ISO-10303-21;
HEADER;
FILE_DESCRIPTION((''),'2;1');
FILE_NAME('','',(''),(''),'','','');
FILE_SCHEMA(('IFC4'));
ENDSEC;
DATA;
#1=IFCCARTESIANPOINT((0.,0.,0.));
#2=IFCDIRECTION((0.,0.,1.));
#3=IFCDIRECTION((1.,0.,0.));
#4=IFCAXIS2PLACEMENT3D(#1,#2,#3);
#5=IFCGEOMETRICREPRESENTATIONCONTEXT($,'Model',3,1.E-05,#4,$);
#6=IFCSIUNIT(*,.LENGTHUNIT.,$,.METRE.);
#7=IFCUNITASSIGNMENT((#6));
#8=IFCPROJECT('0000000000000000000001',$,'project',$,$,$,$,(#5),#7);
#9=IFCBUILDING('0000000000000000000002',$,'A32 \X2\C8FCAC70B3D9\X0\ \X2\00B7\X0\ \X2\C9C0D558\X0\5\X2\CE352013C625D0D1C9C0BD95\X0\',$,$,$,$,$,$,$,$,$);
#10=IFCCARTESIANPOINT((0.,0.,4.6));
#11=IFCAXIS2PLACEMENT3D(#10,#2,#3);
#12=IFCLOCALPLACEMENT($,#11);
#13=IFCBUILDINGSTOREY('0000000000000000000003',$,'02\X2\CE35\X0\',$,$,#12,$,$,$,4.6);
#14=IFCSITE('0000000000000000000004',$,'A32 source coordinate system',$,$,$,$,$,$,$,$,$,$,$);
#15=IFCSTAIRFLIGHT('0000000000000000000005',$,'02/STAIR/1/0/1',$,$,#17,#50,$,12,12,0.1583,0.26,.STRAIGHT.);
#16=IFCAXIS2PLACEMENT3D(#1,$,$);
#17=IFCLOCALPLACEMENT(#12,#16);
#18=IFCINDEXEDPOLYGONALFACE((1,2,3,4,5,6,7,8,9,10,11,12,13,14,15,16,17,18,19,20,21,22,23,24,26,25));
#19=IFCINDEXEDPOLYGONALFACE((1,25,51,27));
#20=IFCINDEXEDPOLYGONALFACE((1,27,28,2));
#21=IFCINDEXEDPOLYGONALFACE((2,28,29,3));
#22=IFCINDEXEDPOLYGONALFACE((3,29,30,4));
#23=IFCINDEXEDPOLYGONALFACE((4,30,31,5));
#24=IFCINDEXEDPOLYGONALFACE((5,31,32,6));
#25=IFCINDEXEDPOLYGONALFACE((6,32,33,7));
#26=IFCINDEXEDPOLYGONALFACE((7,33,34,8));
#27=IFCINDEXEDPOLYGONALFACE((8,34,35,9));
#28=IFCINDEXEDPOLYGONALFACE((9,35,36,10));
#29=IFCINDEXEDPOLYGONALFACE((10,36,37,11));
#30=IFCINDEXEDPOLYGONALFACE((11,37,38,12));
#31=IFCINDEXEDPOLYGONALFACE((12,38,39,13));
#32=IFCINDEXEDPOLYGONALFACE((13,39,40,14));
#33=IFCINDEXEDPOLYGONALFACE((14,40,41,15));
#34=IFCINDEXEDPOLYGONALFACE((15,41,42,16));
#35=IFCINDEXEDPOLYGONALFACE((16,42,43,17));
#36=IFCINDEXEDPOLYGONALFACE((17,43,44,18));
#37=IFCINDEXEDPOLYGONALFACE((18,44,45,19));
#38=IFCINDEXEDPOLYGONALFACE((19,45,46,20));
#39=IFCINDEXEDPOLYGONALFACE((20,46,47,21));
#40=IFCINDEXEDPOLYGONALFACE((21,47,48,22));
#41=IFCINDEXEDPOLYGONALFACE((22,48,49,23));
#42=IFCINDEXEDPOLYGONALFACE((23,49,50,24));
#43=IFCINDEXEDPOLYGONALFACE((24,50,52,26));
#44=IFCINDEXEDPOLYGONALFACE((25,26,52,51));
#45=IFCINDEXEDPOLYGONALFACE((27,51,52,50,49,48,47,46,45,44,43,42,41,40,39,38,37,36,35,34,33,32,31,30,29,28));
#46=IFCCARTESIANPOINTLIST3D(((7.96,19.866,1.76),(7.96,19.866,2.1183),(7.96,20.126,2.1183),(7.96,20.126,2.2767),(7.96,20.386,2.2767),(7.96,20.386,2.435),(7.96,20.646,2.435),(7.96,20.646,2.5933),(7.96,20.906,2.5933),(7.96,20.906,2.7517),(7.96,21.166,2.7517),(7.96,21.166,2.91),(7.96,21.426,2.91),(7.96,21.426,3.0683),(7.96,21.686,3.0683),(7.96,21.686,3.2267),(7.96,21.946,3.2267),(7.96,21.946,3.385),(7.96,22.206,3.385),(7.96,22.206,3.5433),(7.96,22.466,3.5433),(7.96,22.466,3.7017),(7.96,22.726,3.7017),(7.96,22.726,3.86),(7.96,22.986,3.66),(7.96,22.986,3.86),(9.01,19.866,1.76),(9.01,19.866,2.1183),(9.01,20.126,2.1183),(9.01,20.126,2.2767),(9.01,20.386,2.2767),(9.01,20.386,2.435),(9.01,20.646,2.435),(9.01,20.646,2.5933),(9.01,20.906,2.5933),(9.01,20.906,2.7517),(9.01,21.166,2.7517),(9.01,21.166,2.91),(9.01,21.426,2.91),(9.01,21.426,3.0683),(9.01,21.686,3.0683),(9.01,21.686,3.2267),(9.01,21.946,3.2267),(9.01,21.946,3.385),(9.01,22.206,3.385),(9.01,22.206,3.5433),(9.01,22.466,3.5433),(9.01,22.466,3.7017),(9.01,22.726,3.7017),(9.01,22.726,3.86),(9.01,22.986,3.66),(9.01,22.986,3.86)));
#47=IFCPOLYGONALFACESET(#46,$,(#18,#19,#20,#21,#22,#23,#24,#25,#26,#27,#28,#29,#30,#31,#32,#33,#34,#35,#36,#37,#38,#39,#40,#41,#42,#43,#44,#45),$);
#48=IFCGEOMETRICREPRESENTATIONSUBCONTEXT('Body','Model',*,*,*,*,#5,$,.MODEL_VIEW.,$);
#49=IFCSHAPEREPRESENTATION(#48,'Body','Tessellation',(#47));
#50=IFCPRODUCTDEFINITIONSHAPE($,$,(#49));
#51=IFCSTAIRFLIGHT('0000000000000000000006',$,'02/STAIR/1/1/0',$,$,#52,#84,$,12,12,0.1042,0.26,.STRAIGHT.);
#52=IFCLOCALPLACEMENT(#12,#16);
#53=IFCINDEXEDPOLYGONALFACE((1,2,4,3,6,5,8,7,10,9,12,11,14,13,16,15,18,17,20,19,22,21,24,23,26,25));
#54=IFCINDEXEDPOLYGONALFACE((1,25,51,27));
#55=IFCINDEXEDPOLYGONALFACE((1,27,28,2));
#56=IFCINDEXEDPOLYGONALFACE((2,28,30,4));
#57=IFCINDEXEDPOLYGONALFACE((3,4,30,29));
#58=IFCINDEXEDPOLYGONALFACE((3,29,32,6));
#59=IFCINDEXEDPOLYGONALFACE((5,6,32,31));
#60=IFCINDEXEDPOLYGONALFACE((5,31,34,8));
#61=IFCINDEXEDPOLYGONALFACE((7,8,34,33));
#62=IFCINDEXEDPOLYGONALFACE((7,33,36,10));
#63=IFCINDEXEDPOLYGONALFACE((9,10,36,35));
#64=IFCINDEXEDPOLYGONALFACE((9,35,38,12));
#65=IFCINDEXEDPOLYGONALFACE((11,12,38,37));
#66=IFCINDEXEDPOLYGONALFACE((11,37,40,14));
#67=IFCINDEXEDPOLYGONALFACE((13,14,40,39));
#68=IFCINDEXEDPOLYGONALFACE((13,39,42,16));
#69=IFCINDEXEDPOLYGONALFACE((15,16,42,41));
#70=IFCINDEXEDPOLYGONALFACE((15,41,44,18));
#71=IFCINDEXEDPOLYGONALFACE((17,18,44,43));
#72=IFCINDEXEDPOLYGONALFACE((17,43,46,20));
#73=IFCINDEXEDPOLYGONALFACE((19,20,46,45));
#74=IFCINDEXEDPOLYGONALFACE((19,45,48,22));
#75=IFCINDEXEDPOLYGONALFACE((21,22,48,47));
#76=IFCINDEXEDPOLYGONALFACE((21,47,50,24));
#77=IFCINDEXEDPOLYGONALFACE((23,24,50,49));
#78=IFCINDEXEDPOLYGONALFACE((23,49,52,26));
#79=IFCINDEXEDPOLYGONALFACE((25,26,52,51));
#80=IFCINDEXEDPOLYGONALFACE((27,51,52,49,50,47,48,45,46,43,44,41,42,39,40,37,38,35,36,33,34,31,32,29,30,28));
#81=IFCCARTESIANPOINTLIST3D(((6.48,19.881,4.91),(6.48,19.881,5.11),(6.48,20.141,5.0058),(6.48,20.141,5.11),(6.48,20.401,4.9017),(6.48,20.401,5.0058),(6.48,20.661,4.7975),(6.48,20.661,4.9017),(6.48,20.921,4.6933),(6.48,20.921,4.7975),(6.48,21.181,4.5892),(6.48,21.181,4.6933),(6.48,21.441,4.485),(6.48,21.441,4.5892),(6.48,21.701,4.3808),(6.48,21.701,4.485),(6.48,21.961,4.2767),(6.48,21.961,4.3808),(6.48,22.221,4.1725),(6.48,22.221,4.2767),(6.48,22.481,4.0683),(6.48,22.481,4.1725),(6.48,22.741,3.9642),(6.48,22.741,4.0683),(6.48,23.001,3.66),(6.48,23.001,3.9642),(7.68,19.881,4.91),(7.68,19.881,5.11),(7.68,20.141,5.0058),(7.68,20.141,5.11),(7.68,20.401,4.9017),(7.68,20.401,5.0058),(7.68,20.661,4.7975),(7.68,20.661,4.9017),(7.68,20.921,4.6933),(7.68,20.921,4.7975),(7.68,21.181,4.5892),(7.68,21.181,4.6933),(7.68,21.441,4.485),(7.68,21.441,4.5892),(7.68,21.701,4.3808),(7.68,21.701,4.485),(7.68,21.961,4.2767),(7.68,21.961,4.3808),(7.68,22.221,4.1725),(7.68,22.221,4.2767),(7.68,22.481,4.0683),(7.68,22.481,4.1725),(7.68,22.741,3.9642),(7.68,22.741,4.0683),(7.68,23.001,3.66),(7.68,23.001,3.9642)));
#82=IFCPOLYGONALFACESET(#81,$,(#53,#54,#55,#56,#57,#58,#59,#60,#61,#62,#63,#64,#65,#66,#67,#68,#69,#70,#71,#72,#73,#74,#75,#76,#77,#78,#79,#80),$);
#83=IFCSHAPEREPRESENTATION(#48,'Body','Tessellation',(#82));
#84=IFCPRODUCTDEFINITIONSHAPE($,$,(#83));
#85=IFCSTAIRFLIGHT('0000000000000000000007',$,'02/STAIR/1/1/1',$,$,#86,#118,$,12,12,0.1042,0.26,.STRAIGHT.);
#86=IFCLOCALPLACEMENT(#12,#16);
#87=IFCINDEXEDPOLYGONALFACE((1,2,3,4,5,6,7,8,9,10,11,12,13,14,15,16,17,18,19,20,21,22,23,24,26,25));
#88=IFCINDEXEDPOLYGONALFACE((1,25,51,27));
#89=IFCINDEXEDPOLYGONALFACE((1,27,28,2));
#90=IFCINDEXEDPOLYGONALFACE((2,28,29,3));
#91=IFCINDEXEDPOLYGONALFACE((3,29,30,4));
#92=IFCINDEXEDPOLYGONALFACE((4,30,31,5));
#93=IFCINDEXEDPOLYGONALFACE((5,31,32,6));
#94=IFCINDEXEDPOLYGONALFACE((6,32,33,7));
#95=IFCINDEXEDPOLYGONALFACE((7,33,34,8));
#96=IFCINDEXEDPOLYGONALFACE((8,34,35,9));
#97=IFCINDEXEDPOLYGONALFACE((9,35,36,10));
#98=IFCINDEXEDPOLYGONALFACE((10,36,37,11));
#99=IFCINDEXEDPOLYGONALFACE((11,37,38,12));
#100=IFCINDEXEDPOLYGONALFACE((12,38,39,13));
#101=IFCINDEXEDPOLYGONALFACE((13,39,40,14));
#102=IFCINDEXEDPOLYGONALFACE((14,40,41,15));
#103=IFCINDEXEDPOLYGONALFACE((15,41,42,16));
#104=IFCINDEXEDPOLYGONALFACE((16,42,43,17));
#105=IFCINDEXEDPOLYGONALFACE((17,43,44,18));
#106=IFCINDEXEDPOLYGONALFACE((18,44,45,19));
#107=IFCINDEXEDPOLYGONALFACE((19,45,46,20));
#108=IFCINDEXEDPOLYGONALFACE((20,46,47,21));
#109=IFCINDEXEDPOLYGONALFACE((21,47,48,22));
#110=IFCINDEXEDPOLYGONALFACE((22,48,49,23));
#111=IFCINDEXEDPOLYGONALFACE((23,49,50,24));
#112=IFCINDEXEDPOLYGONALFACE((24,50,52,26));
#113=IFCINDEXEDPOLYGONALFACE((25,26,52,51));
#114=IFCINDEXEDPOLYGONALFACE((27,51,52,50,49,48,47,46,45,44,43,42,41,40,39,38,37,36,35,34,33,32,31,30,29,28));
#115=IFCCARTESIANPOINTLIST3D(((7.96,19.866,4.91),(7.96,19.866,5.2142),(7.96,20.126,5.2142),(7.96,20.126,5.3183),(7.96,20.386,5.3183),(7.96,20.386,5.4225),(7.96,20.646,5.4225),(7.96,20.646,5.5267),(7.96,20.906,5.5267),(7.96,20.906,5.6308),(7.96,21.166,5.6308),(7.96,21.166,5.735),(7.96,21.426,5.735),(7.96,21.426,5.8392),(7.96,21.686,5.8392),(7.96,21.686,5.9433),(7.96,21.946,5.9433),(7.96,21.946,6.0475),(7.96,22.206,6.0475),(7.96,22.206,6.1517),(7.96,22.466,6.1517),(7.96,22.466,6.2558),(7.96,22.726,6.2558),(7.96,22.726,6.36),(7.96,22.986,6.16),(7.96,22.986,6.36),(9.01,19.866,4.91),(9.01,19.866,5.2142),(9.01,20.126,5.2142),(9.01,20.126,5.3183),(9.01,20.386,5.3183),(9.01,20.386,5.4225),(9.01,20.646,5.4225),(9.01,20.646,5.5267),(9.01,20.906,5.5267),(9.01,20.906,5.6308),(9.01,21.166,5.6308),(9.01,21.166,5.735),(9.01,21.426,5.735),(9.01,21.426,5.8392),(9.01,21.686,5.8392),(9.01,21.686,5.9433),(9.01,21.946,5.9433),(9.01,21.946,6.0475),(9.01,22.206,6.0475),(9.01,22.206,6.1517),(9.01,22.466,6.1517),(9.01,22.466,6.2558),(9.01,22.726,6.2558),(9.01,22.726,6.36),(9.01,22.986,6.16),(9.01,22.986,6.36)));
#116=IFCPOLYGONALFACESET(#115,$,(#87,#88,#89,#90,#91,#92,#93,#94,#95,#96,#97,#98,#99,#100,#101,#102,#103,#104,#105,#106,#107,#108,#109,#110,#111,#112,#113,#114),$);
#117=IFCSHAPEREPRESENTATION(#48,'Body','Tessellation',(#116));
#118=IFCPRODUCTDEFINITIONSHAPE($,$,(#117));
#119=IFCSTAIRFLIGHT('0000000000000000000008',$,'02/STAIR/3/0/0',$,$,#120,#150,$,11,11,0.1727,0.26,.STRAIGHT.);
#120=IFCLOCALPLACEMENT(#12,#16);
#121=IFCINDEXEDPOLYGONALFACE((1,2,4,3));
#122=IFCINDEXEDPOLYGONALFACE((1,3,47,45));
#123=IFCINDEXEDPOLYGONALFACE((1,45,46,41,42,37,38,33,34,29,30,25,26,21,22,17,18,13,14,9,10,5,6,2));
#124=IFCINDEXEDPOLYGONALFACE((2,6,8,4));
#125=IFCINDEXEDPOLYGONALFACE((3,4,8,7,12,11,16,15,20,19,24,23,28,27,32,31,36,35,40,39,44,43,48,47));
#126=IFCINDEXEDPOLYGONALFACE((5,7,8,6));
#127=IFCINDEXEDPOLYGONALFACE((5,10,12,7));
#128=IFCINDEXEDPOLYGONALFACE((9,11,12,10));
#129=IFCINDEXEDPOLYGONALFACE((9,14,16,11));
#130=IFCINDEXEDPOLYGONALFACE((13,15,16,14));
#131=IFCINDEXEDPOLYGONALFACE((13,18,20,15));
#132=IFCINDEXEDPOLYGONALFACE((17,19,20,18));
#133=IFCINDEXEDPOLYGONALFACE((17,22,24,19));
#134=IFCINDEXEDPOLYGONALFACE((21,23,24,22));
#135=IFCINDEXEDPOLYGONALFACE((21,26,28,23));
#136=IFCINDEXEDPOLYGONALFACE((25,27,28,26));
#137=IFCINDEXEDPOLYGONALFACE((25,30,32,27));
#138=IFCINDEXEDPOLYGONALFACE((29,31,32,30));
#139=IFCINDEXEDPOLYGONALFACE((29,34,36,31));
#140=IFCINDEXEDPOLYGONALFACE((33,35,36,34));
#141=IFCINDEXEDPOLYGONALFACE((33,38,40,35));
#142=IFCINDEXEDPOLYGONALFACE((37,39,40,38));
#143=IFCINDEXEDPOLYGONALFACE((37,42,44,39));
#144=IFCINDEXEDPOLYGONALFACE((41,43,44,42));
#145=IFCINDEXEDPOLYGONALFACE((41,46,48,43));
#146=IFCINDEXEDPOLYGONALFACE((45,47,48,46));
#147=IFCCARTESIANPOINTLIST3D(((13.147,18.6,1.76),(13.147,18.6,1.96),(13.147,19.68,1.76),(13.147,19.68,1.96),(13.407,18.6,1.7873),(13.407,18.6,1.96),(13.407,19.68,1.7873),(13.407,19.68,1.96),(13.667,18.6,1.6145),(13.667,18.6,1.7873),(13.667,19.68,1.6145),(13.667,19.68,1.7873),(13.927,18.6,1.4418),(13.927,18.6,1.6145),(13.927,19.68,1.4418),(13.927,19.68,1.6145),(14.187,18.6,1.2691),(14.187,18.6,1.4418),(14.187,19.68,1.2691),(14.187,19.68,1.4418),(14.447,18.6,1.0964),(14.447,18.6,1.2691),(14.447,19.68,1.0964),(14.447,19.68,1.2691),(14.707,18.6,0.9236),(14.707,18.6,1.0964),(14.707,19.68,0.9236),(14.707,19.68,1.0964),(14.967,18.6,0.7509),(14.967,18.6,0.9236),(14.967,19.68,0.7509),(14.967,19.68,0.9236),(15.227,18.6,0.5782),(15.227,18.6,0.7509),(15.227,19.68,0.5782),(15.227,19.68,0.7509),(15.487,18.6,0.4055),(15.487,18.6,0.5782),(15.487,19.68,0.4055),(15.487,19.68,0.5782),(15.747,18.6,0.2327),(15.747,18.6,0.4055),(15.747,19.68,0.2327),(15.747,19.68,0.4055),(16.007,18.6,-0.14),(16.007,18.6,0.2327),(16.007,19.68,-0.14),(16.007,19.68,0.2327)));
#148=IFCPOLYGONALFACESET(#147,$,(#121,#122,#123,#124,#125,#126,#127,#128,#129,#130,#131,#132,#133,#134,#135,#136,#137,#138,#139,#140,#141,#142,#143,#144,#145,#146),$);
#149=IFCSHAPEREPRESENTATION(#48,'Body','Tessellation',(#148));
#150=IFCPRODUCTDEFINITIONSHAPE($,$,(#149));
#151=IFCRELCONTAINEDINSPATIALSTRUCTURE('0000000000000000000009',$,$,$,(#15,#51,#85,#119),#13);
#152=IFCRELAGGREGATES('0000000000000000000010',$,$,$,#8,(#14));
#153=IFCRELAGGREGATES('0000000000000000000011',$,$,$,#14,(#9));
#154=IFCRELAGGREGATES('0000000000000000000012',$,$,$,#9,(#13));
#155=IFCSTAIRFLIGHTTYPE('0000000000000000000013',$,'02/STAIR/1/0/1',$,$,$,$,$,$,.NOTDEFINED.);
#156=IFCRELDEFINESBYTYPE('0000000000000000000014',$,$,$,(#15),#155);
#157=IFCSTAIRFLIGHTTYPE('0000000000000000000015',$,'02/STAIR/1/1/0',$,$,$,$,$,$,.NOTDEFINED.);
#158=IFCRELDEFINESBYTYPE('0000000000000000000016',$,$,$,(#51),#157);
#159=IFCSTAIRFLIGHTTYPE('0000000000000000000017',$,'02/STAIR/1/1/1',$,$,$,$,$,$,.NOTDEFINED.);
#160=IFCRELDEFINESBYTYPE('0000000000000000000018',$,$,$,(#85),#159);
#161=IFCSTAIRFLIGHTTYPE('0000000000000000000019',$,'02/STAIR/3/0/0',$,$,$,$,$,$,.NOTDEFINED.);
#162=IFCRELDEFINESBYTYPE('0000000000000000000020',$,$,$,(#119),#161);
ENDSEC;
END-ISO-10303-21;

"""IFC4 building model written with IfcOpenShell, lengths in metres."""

from ifc_helpers import new_model, si_unit, frame, origin, origin_with_axes, place, context, subcontext, project, spatial, polyline, outline, extrude, source, transform, mapped, type_object, type_shapes, element, save


model = new_model("IFC4")

# Units and contexts
model_context = context("Model", 3, precision=1e-05, world=origin_with_axes())
body_context = subcontext(model_context, "Body", "Model", "MODEL_VIEW")
ifc_project = project(units=[si_unit("LENGTHUNIT", "METRE")], contexts=[model_context])

# Site, building, storey
storey_placement = place(None, frame((0.0, 0.0, 4.6), z_axis=(0.0, 0.0, 1.0), x_axis=(1.0, 0.0, 0.0)))
site = spatial("IfcSite", under=ifc_project, Name="A32 source coordinate system")
building = spatial("IfcBuilding", under=site, Name="A32 주거동 · 지하5층–옥탑지붕")
storey = spatial("IfcBuildingStorey", under=building, at=storey_placement, Name="02층", Elevation=4.6)

# Stair flights
stair_flight_type_1 = type_object("IfcStairFlightType", Name="02/STAIR/1/0/1", PredefinedType="NOTDEFINED")
shared_shape_1 = source(origin(), body_context, "Body", "SweptSolid", [
    extrude(outline(polyline([(0.0, 1.76), (3.12, 3.66), (3.12, 3.86), (2.86, 3.86), (2.86, 3.7017), (2.6, 3.7017), (2.6, 3.5433), (2.34, 3.5433), (2.34, 3.385), (2.08, 3.385), (2.08, 3.2267), (1.82, 3.2267), (1.82, 3.0683), (1.56, 3.0683), (1.56, 2.91), (1.3, 2.91), (1.3, 2.7517), (1.04, 2.7517), (1.04, 2.5933), (0.78, 2.5933), (0.78, 2.435), (0.52, 2.435), (0.52, 2.2767), (0.26, 2.2767), (0.26, 2.1183), (0.0, 2.1183), (0.0, 1.76)])), frame((7.96, 19.866, 0.0), z_axis=(1.0, 0.0, 0.0), x_axis=(0.0, 1.0, 0.0)), (0.0, 0.0, 1.0), 1.05),
])
type_shapes(stair_flight_type_1, [shared_shape_1])
stair_flight_1_placement = place(storey_placement, origin_with_axes())
element("IfcStairFlight", 1, at=stair_flight_1_placement, inside=storey, type_object=stair_flight_type_1, Name="02/STAIR/1/0/1", NumberOfRisers=12, NumberOfTreads=12, PredefinedType="STRAIGHT", RiserHeight=0.1583, TreadLength=0.26, context=body_context, shape_type="MappedRepresentation", body=[
    mapped(shared_shape_1, transform((0.0, 0.0, 0.0), scale=1.0)),
])
stair_flight_type_2 = type_object("IfcStairFlightType", Name="02/STAIR/1/1/0", PredefinedType="NOTDEFINED")
shared_shape_2 = source(origin(), body_context, "Body", "SweptSolid", [
    extrude(outline(polyline([(0.0, 3.66), (3.12, 4.91), (3.12, 5.11), (2.86, 5.11), (2.86, 5.0058), (2.6, 5.0058), (2.6, 4.9017), (2.34, 4.9017), (2.34, 4.7975), (2.08, 4.7975), (2.08, 4.6933), (1.82, 4.6933), (1.82, 4.5892), (1.56, 4.5892), (1.56, 4.485), (1.3, 4.485), (1.3, 4.3808), (1.04, 4.3808), (1.04, 4.2767), (0.78, 4.2767), (0.78, 4.1725), (0.52, 4.1725), (0.52, 4.0683), (0.26, 4.0683), (0.26, 3.9642), (0.0, 3.9642), (0.0, 3.66)])), frame((7.68, 23.001, 0.0), z_axis=(-1.0, 0.0, 0.0), x_axis=(0.0, -1.0, 0.0)), (0.0, 0.0, 1.0), 1.2),
])
type_shapes(stair_flight_type_2, [shared_shape_2])
stair_flight_2_placement = place(storey_placement, origin_with_axes())
element("IfcStairFlight", 2, at=stair_flight_2_placement, inside=storey, type_object=stair_flight_type_2, Name="02/STAIR/1/1/0", NumberOfRisers=12, NumberOfTreads=12, PredefinedType="STRAIGHT", RiserHeight=0.1042, TreadLength=0.26, context=body_context, shape_type="MappedRepresentation", body=[
    mapped(shared_shape_2, transform((0.0, 0.0, 0.0), scale=1.0)),
])
stair_flight_type_3 = type_object("IfcStairFlightType", Name="02/STAIR/1/1/1", PredefinedType="NOTDEFINED")
shared_shape_3 = source(origin(), body_context, "Body", "SweptSolid", [
    extrude(outline(polyline([(0.0, 4.91), (3.12, 6.16), (3.12, 6.36), (2.86, 6.36), (2.86, 6.2558), (2.6, 6.2558), (2.6, 6.1517), (2.34, 6.1517), (2.34, 6.0475), (2.08, 6.0475), (2.08, 5.9433), (1.82, 5.9433), (1.82, 5.8392), (1.56, 5.8392), (1.56, 5.735), (1.3, 5.735), (1.3, 5.6308), (1.04, 5.6308), (1.04, 5.5267), (0.78, 5.5267), (0.78, 5.4225), (0.52, 5.4225), (0.52, 5.3183), (0.26, 5.3183), (0.26, 5.2142), (0.0, 5.2142), (0.0, 4.91)])), frame((7.96, 19.866, 0.0), z_axis=(1.0, 0.0, 0.0), x_axis=(0.0, 1.0, 0.0)), (0.0, 0.0, 1.0), 1.05),
])
type_shapes(stair_flight_type_3, [shared_shape_3])
stair_flight_3_placement = place(storey_placement, origin_with_axes())
element("IfcStairFlight", 3, at=stair_flight_3_placement, inside=storey, type_object=stair_flight_type_3, Name="02/STAIR/1/1/1", NumberOfRisers=12, NumberOfTreads=12, PredefinedType="STRAIGHT", RiserHeight=0.1042, TreadLength=0.26, context=body_context, shape_type="MappedRepresentation", body=[
    mapped(shared_shape_3, transform((0.0, 0.0, 0.0), scale=1.0)),
])
stair_flight_type_4 = type_object("IfcStairFlightType", Name="02/STAIR/3/0/0", PredefinedType="NOTDEFINED")
shared_shape_4 = source(origin(), body_context, "Body", "SweptSolid", [
    extrude(outline(polyline([(0.0, -0.14), (2.86, 1.76), (2.86, 1.96), (2.6, 1.96), (2.6, 1.7873), (2.34, 1.7873), (2.34, 1.6145), (2.08, 1.6145), (2.08, 1.4418), (1.82, 1.4418), (1.82, 1.2691), (1.56, 1.2691), (1.56, 1.0964), (1.3, 1.0964), (1.3, 0.9236), (1.04, 0.9236), (1.04, 0.7509), (0.78, 0.7509), (0.78, 0.5782), (0.52, 0.5782), (0.52, 0.4055), (0.26, 0.4055), (0.26, 0.2327), (0.0, 0.2327), (0.0, -0.14)])), frame((16.007, 18.6, 0.0), z_axis=(0.0, 1.0, 0.0), x_axis=(-1.0, 0.0, 0.0)), (0.0, 0.0, 1.0), 1.08),
])
type_shapes(stair_flight_type_4, [shared_shape_4])
stair_flight_4_placement = place(storey_placement, origin_with_axes())
element("IfcStairFlight", 4, at=stair_flight_4_placement, inside=storey, type_object=stair_flight_type_4, Name="02/STAIR/3/0/0", NumberOfRisers=11, NumberOfTreads=11, PredefinedType="STRAIGHT", RiserHeight=0.1727, TreadLength=0.26, context=body_context, shape_type="MappedRepresentation", body=[
    mapped(shared_shape_4, transform((0.0, 0.0, 0.0), scale=1.0)),
])

save(model, "model.ifc")
